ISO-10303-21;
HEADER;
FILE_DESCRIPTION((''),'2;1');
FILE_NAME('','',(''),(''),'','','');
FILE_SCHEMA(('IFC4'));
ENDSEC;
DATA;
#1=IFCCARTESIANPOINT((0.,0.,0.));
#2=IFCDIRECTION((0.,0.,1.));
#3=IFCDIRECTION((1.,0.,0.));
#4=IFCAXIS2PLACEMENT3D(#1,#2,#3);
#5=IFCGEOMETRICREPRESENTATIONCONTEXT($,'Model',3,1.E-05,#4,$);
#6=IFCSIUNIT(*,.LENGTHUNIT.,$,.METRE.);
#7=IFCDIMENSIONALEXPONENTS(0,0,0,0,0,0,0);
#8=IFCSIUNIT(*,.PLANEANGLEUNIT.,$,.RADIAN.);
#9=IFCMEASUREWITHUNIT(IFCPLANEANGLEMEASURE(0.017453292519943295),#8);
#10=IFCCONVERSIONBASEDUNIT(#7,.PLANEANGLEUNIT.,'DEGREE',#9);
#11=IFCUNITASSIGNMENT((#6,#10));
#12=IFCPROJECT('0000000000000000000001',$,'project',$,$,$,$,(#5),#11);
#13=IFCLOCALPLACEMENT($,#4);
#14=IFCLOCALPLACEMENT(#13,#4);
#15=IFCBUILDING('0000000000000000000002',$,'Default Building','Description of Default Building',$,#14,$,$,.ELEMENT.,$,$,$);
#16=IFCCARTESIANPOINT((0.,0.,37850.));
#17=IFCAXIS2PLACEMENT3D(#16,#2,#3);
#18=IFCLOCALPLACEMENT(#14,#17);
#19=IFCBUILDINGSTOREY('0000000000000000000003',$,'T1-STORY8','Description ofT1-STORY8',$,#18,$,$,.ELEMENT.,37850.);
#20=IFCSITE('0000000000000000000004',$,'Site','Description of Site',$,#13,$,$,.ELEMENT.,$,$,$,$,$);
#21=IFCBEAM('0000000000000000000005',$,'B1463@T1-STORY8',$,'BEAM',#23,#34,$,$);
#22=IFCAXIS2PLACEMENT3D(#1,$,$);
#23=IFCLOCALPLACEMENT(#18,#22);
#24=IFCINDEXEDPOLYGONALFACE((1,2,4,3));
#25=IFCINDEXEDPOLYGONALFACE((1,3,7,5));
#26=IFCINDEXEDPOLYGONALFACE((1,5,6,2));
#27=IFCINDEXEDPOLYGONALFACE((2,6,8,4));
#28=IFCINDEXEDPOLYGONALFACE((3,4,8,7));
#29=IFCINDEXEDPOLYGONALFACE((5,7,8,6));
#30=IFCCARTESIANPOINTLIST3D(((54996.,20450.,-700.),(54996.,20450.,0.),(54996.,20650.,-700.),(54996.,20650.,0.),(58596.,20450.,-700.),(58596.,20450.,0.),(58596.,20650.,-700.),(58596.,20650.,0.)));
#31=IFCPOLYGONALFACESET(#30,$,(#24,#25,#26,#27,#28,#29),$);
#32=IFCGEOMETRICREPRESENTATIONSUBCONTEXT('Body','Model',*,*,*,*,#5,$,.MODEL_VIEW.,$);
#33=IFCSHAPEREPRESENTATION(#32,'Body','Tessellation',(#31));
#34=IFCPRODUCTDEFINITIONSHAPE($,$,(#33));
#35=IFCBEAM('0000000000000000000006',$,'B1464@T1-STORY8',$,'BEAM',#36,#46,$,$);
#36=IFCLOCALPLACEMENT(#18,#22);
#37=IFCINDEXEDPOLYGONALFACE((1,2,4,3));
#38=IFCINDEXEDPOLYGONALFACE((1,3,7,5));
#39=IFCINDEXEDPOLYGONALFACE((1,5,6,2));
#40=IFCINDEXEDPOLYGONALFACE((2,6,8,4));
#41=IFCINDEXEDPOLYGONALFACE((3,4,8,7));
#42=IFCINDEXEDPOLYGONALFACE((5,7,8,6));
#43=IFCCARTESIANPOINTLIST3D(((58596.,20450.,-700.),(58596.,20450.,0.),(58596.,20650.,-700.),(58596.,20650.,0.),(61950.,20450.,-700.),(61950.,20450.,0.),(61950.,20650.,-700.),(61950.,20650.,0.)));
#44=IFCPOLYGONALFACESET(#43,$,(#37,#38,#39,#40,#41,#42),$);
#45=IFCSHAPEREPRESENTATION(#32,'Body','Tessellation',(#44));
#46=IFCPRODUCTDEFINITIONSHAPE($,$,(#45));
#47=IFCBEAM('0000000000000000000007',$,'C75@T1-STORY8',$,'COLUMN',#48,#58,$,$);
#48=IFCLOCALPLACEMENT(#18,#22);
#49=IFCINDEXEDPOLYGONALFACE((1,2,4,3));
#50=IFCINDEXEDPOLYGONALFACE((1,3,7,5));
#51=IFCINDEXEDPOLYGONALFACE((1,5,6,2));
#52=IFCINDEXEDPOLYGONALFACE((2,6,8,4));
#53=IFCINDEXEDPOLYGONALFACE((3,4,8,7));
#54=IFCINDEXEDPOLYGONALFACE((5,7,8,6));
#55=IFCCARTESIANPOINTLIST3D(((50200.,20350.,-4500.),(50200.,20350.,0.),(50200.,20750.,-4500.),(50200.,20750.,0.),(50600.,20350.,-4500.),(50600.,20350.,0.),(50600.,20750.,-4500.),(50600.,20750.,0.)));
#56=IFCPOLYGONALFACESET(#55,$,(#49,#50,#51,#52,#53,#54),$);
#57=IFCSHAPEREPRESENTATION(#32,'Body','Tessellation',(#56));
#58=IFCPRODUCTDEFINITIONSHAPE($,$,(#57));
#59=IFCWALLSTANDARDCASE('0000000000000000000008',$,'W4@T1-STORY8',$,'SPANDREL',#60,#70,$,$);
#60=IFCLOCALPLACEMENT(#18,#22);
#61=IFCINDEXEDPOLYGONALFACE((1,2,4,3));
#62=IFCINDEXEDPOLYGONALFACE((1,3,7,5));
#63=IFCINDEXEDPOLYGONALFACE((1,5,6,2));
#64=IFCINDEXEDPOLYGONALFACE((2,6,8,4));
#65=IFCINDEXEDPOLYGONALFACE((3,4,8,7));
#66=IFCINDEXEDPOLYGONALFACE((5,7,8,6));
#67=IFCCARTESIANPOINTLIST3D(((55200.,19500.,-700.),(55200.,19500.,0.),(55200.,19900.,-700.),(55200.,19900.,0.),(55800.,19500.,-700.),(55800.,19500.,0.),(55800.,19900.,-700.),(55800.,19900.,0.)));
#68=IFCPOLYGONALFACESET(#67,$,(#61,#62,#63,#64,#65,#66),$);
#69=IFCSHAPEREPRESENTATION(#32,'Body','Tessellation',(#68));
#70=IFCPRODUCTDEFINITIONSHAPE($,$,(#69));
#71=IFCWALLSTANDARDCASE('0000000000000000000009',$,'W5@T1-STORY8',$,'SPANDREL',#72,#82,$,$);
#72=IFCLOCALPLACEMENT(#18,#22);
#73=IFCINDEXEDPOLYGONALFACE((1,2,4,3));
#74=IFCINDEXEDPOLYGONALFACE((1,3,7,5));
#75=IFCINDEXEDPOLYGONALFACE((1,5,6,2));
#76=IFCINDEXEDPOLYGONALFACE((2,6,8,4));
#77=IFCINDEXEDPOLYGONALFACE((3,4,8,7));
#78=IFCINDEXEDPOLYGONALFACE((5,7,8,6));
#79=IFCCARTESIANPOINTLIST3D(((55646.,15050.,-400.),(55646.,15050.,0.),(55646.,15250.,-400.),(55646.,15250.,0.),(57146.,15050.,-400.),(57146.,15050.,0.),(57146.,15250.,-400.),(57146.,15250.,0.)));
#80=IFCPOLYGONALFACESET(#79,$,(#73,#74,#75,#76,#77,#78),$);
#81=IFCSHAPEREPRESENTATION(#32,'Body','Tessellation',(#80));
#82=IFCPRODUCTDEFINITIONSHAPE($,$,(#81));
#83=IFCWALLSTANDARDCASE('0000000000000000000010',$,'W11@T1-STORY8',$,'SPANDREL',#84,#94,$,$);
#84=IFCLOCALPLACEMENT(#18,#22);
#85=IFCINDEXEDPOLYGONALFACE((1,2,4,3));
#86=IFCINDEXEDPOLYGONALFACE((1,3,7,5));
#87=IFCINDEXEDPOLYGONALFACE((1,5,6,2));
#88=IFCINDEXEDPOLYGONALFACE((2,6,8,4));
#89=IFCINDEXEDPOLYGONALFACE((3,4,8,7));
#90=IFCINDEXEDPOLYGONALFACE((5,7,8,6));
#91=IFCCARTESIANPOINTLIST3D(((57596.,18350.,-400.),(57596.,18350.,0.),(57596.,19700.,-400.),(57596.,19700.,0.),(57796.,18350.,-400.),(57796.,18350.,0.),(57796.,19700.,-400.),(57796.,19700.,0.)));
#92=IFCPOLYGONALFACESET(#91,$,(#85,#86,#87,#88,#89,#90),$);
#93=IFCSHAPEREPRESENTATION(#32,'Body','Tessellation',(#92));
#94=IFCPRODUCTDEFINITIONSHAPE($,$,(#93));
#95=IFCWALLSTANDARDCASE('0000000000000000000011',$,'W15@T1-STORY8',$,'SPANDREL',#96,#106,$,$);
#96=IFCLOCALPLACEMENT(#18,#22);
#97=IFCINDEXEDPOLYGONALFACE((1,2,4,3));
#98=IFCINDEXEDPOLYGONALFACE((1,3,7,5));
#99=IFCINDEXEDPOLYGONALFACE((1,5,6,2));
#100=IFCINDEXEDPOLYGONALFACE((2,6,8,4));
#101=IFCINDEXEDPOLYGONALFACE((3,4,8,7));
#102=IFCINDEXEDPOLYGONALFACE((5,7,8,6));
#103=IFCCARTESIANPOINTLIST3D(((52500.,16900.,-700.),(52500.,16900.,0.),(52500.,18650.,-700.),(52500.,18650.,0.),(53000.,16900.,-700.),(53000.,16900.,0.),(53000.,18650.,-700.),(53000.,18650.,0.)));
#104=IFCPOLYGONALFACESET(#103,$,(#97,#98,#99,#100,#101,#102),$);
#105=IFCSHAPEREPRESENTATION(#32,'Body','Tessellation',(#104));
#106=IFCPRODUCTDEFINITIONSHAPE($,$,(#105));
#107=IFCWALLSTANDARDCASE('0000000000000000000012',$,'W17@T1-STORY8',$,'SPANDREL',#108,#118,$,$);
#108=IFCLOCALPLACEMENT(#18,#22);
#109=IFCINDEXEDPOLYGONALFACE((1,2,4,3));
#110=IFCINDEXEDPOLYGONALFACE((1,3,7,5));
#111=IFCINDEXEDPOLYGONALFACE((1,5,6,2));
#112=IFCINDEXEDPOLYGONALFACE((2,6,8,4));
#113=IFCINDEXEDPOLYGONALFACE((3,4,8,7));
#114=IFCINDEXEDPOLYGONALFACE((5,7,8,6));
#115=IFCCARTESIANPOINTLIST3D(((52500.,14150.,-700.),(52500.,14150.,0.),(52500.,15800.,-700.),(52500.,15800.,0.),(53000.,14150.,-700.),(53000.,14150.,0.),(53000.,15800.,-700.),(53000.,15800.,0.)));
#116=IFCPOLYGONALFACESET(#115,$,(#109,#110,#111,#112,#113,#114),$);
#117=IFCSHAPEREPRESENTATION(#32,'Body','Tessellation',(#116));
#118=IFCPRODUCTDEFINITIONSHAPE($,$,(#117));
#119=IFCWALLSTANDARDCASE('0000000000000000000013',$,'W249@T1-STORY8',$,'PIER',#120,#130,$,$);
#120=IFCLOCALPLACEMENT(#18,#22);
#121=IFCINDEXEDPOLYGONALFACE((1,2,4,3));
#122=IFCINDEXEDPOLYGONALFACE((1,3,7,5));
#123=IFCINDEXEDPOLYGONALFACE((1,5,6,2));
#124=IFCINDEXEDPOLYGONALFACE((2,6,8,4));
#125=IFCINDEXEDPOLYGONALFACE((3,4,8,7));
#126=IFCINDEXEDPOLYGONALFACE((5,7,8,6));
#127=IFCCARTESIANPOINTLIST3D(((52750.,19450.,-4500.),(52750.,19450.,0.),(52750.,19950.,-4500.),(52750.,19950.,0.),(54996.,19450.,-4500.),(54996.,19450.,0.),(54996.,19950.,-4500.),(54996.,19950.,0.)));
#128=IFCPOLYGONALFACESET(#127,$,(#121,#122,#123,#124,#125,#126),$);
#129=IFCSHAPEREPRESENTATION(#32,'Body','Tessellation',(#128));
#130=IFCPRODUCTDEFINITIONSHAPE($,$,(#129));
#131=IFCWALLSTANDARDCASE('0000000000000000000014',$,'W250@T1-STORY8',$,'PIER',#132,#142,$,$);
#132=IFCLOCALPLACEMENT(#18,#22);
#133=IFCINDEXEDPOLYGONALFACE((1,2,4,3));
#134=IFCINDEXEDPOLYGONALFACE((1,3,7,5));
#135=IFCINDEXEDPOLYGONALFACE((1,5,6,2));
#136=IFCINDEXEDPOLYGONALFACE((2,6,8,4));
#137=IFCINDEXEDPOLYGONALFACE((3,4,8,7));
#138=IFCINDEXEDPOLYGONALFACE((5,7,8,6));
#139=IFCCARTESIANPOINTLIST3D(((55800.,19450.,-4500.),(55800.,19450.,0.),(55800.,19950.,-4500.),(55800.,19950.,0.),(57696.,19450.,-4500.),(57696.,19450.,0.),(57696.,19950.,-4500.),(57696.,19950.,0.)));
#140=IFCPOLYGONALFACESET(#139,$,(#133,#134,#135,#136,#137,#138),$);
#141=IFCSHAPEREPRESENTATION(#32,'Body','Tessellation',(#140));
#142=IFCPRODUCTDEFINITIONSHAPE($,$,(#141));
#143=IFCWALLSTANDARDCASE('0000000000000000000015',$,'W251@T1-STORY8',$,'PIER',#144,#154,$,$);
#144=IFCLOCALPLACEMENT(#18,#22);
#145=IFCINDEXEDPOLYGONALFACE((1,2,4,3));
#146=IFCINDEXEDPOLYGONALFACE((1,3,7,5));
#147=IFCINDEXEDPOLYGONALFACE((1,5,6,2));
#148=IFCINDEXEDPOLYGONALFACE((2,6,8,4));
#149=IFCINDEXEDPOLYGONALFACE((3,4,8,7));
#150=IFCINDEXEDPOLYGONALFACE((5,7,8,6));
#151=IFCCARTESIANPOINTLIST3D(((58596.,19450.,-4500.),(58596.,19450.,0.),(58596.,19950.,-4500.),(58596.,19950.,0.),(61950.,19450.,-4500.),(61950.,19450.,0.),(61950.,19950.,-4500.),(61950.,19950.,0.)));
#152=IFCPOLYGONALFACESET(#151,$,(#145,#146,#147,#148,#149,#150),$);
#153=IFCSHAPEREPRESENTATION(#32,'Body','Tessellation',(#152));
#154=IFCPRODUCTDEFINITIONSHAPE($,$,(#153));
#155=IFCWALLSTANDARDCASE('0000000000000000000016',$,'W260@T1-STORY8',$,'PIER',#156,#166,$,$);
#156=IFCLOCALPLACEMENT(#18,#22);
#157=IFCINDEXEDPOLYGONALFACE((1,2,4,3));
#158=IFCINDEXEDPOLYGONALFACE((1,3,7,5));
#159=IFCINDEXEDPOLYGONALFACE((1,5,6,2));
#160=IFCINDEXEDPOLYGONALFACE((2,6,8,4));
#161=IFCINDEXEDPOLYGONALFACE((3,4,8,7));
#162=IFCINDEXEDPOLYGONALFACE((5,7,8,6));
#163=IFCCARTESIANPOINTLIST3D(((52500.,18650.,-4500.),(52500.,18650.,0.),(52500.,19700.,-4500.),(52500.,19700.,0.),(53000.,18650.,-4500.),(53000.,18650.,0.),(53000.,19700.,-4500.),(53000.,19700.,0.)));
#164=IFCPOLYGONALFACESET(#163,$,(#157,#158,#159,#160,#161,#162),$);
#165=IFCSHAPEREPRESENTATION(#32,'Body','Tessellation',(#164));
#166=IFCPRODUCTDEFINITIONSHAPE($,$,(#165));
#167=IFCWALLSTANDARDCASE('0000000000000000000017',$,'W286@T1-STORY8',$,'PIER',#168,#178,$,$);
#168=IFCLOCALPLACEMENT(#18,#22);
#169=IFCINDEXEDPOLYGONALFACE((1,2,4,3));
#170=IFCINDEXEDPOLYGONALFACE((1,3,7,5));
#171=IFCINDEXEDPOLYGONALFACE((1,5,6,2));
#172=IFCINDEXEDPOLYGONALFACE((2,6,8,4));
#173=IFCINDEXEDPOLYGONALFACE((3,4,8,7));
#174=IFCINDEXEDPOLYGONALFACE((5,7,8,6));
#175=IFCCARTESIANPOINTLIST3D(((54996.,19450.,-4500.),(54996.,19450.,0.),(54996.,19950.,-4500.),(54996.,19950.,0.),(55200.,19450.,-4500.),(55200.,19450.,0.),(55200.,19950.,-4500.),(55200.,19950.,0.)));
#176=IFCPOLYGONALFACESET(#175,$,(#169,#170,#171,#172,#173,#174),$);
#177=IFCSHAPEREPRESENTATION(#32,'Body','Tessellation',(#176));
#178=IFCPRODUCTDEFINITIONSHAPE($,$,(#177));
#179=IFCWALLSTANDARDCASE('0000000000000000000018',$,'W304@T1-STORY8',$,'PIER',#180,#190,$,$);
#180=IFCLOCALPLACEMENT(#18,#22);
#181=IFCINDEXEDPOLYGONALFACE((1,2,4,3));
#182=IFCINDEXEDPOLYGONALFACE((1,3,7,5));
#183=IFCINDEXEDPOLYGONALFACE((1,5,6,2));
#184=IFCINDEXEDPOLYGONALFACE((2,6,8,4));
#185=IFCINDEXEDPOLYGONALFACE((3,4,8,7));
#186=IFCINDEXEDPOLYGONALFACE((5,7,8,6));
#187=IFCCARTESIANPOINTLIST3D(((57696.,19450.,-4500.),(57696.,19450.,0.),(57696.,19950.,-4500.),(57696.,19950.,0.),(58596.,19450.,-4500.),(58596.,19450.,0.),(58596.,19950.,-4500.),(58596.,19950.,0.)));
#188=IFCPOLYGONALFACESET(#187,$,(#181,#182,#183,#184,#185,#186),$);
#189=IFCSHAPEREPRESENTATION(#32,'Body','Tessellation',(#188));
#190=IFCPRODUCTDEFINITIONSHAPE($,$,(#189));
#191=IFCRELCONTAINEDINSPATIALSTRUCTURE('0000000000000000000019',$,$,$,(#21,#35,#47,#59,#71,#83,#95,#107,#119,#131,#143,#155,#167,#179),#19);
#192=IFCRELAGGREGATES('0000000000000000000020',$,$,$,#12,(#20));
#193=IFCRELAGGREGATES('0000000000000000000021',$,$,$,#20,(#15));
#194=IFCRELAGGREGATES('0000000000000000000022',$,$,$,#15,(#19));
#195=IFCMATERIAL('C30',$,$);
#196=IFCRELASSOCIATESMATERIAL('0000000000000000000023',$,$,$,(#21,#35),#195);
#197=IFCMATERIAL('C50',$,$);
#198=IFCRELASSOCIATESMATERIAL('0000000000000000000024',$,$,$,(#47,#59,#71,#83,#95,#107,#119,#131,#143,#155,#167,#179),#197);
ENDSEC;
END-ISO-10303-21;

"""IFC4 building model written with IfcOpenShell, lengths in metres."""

from ifc_helpers import new_model, entity, si_unit, converted_unit, frame, origin_with_axes, place, context, subcontext, project, spatial, indexed_curve, rectangle, outline, extrude, material, element, save


model = new_model("IFC4")

# Units and contexts
model_context = context("Model", 3, precision=1e-05, world=origin_with_axes())
body_context = subcontext(model_context, "Body", "Model", "MODEL_VIEW")
ifc_project = project(units=[si_unit("LENGTHUNIT", "METRE"), converted_unit("PLANEANGLEUNIT", "DEGREE", entity("IfcPlaneAngleMeasure", 0.017453292519943295), si_unit("PLANEANGLEUNIT", "RADIAN"), dimensions=[0, 0, 0, 0, 0, 0, 0])], contexts=[model_context])

# Site, building, storey
site_placement = place(None, origin_with_axes())
site = spatial("IfcSite", under=ifc_project, at=site_placement, Name="Site", Description="Description of Site", CompositionType="ELEMENT")
building_placement = place(site_placement, origin_with_axes())
building = spatial("IfcBuilding", under=site, at=building_placement, Name="Default Building", Description="Description of Default Building", CompositionType="ELEMENT")
storey_placement = place(building_placement, frame((0.0, 0.0, 37850.0), z_axis=(0.0, 0.0, 1.0), x_axis=(1.0, 0.0, 0.0)))
storey = spatial("IfcBuildingStorey", under=building, at=storey_placement, Name="T1-STORY8", Description="Description ofT1-STORY8", CompositionType="ELEMENT", Elevation=37850.0)

# Beams
ifc_material_1 = material(Name="C30")
beam_1_placement = place(storey_placement, frame((54996.0, 20550.0, -350.0), z_axis=(1.0, 0.0, 0.0), x_axis=(0.0, 1.0, 0.0)))
element("IfcBeam", 1, at=beam_1_placement, inside=storey, material=ifc_material_1, Name="B1463@T1-STORY8", ObjectType="BEAM", context=body_context, shape_type="SweptSolid", body=[
    extrude(rectangle(XDim=200.0, YDim=700.0), origin_with_axes(), (0.0, 0.0, 1.0), 3600.0),
])
beam_2_placement = place(storey_placement, frame((58596.0, 20550.0, -350.0), z_axis=(1.0, 0.0, 0.0), x_axis=(0.0, 1.0, 0.0)))
element("IfcBeam", 2, at=beam_2_placement, inside=storey, material=ifc_material_1, Name="B1464@T1-STORY8", ObjectType="BEAM", context=body_context, shape_type="SweptSolid", body=[
    extrude(rectangle(XDim=200.0, YDim=700.0), origin_with_axes(), (0.0, 0.0, 1.0), 3354.0),
])
ifc_material_2 = material(Name="C50")
beam_3_placement = place(storey_placement, frame((50400.0, 20550.0, -4500.0), z_axis=(0.0, 0.0, 1.0), x_axis=(-1.0, 0.0, 0.0)))
element("IfcBeam", 3, at=beam_3_placement, inside=storey, material=ifc_material_2, Name="C75@T1-STORY8", ObjectType="COLUMN", context=body_context, shape_type="SweptSolid", body=[
    extrude(rectangle(XDim=400.0, YDim=400.0), origin_with_axes(), (0.0, 0.0, 1.0), 4500.0),
])

# Walls
wall_1_placement = place(storey_placement, frame((55200.0, 19700.0, -700.0), z_axis=(0.0, 0.0, 1.0), x_axis=(1.0, 0.0, 0.0)))
element("IfcWallStandardCase", 4, at=wall_1_placement, inside=storey, material=ifc_material_2, Name="W4@T1-STORY8", ObjectType="SPANDREL", context=body_context, shape_type="SweptSolid", body=[
    extrude(outline(indexed_curve([(0.0, -200.0), (0.0, 200.0), (600.0, 200.0), (600.0, -200.0), (0.0, -200.0)], self_intersect=False)), origin_with_axes(), (0.0, 0.0, 1.0), 700.0),
])
wall_2_placement = place(storey_placement, frame((55646.0, 15150.0, -400.0), z_axis=(0.0, 0.0, 1.0), x_axis=(1.0, 0.0, 0.0)))
element("IfcWallStandardCase", 5, at=wall_2_placement, inside=storey, material=ifc_material_2, Name="W5@T1-STORY8", ObjectType="SPANDREL", context=body_context, shape_type="SweptSolid", body=[
    extrude(outline(indexed_curve([(0.0, -100.0), (0.0, 100.0), (1500.0, 100.0), (1500.0, -100.0), (0.0, -100.0)], self_intersect=False)), origin_with_axes(), (0.0, 0.0, 1.0), 400.0),
])
wall_3_placement = place(storey_placement, frame((57696.0, 18350.0, -400.0), z_axis=(0.0, 0.0, 1.0), x_axis=(0.0, 1.0, 0.0)))
element("IfcWallStandardCase", 6, at=wall_3_placement, inside=storey, material=ifc_material_2, Name="W11@T1-STORY8", ObjectType="SPANDREL", context=body_context, shape_type="SweptSolid", body=[
    extrude(outline(indexed_curve([(0.0, -100.0), (0.0, 100.0), (1350.0, 100.0), (1350.0, -100.0), (0.0, -100.0)], self_intersect=False)), origin_with_axes(), (0.0, 0.0, 1.0), 400.0),
])
wall_4_placement = place(storey_placement, frame((52750.0, 16900.0, -700.0), z_axis=(0.0, 0.0, 1.0), x_axis=(0.0, 1.0, 0.0)))
element("IfcWallStandardCase", 7, at=wall_4_placement, inside=storey, material=ifc_material_2, Name="W15@T1-STORY8", ObjectType="SPANDREL", context=body_context, shape_type="SweptSolid", body=[
    extrude(outline(indexed_curve([(0.0, -250.0), (0.0, 250.0), (1750.0, 250.0), (1750.0, -250.0), (0.0, -250.0)], self_intersect=False)), origin_with_axes(), (0.0, 0.0, 1.0), 700.0),
])
wall_5_placement = place(storey_placement, frame((52750.0, 14150.0, -700.0), z_axis=(0.0, 0.0, 1.0), x_axis=(0.0, 1.0, 0.0)))
element("IfcWallStandardCase", 8, at=wall_5_placement, inside=storey, material=ifc_material_2, Name="W17@T1-STORY8", ObjectType="SPANDREL", context=body_context, shape_type="SweptSolid", body=[
    extrude(outline(indexed_curve([(0.0, -250.0), (0.0, 250.0), (1650.0, 250.0), (1650.0, -250.0), (0.0, -250.0)], self_intersect=False)), origin_with_axes(), (0.0, 0.0, 1.0), 700.0),
])
wall_6_placement = place(storey_placement, frame((52750.0, 19700.0, -4500.0), z_axis=(0.0, 0.0, 1.0), x_axis=(1.0, 0.0, 0.0)))
element("IfcWallStandardCase", 9, at=wall_6_placement, inside=storey, material=ifc_material_2, Name="W249@T1-STORY8", ObjectType="PIER", context=body_context, shape_type="SweptSolid", body=[
    extrude(outline(indexed_curve([(0.0, -250.0), (0.0, 250.0), (2246.0, 250.0), (2246.0, -250.0), (0.0, -250.0)], self_intersect=False)), origin_with_axes(), (0.0, 0.0, 1.0), 4500.0),
])
wall_7_placement = place(storey_placement, frame((55800.0, 19700.0, -4500.0), z_axis=(0.0, 0.0, 1.0), x_axis=(1.0, 0.0, 0.0)))
element("IfcWallStandardCase", 10, at=wall_7_placement, inside=storey, material=ifc_material_2, Name="W250@T1-STORY8", ObjectType="PIER", context=body_context, shape_type="SweptSolid", body=[
    extrude(outline(indexed_curve([(0.0, -250.0), (0.0, 250.0), (1896.0, 250.0), (1896.0, -250.0), (0.0, -250.0)], self_intersect=False)), origin_with_axes(), (0.0, 0.0, 1.0), 4500.0),
])
wall_8_placement = place(storey_placement, frame((58596.0, 19700.0, -4500.0), z_axis=(0.0, 0.0, 1.0), x_axis=(1.0, 0.0, 0.0)))
element("IfcWallStandardCase", 11, at=wall_8_placement, inside=storey, material=ifc_material_2, Name="W251@T1-STORY8", ObjectType="PIER", context=body_context, shape_type="SweptSolid", body=[
    extrude(outline(indexed_curve([(0.0, -250.0), (0.0, 250.0), (3354.0, 250.0), (3354.0, -250.0), (0.0, -250.0)], self_intersect=False)), origin_with_axes(), (0.0, 0.0, 1.0), 4500.0),
])
wall_9_placement = place(storey_placement, frame((52750.0, 18650.0, -4500.0), z_axis=(0.0, 0.0, 1.0), x_axis=(0.0, 1.0, 0.0)))
element("IfcWallStandardCase", 12, at=wall_9_placement, inside=storey, material=ifc_material_2, Name="W260@T1-STORY8", ObjectType="PIER", context=body_context, shape_type="SweptSolid", body=[
    extrude(outline(indexed_curve([(0.0, -250.0), (0.0, 250.0), (1050.0, 250.0), (1050.0, -250.0), (0.0, -250.0)], self_intersect=False)), origin_with_axes(), (0.0, 0.0, 1.0), 4500.0),
])
wall_10_placement = place(storey_placement, frame((54996.0, 19700.0, -4500.0), z_axis=(0.0, 0.0, 1.0), x_axis=(1.0, 0.0, 0.0)))
element("IfcWallStandardCase", 13, at=wall_10_placement, inside=storey, material=ifc_material_2, Name="W286@T1-STORY8", ObjectType="PIER", context=body_context, shape_type="SweptSolid", body=[
    extrude(outline(indexed_curve([(0.0, -250.0), (0.0, 250.0), (204.0, 250.0), (204.0, -250.0), (0.0, -250.0)], self_intersect=False)), origin_with_axes(), (0.0, 0.0, 1.0), 4500.0),
])
wall_11_placement = place(storey_placement, frame((57696.0, 19700.0, -4500.0), z_axis=(0.0, 0.0, 1.0), x_axis=(1.0, 0.0, 0.0)))
element("IfcWallStandardCase", 14, at=wall_11_placement, inside=storey, material=ifc_material_2, Name="W304@T1-STORY8", ObjectType="PIER", context=body_context, shape_type="SweptSolid", body=[
    extrude(outline(indexed_curve([(0.0, -250.0), (0.0, 250.0), (900.0, 250.0), (900.0, -250.0), (0.0, -250.0)], self_intersect=False)), origin_with_axes(), (0.0, 0.0, 1.0), 4500.0),
])

save(model, "model.ifc")
